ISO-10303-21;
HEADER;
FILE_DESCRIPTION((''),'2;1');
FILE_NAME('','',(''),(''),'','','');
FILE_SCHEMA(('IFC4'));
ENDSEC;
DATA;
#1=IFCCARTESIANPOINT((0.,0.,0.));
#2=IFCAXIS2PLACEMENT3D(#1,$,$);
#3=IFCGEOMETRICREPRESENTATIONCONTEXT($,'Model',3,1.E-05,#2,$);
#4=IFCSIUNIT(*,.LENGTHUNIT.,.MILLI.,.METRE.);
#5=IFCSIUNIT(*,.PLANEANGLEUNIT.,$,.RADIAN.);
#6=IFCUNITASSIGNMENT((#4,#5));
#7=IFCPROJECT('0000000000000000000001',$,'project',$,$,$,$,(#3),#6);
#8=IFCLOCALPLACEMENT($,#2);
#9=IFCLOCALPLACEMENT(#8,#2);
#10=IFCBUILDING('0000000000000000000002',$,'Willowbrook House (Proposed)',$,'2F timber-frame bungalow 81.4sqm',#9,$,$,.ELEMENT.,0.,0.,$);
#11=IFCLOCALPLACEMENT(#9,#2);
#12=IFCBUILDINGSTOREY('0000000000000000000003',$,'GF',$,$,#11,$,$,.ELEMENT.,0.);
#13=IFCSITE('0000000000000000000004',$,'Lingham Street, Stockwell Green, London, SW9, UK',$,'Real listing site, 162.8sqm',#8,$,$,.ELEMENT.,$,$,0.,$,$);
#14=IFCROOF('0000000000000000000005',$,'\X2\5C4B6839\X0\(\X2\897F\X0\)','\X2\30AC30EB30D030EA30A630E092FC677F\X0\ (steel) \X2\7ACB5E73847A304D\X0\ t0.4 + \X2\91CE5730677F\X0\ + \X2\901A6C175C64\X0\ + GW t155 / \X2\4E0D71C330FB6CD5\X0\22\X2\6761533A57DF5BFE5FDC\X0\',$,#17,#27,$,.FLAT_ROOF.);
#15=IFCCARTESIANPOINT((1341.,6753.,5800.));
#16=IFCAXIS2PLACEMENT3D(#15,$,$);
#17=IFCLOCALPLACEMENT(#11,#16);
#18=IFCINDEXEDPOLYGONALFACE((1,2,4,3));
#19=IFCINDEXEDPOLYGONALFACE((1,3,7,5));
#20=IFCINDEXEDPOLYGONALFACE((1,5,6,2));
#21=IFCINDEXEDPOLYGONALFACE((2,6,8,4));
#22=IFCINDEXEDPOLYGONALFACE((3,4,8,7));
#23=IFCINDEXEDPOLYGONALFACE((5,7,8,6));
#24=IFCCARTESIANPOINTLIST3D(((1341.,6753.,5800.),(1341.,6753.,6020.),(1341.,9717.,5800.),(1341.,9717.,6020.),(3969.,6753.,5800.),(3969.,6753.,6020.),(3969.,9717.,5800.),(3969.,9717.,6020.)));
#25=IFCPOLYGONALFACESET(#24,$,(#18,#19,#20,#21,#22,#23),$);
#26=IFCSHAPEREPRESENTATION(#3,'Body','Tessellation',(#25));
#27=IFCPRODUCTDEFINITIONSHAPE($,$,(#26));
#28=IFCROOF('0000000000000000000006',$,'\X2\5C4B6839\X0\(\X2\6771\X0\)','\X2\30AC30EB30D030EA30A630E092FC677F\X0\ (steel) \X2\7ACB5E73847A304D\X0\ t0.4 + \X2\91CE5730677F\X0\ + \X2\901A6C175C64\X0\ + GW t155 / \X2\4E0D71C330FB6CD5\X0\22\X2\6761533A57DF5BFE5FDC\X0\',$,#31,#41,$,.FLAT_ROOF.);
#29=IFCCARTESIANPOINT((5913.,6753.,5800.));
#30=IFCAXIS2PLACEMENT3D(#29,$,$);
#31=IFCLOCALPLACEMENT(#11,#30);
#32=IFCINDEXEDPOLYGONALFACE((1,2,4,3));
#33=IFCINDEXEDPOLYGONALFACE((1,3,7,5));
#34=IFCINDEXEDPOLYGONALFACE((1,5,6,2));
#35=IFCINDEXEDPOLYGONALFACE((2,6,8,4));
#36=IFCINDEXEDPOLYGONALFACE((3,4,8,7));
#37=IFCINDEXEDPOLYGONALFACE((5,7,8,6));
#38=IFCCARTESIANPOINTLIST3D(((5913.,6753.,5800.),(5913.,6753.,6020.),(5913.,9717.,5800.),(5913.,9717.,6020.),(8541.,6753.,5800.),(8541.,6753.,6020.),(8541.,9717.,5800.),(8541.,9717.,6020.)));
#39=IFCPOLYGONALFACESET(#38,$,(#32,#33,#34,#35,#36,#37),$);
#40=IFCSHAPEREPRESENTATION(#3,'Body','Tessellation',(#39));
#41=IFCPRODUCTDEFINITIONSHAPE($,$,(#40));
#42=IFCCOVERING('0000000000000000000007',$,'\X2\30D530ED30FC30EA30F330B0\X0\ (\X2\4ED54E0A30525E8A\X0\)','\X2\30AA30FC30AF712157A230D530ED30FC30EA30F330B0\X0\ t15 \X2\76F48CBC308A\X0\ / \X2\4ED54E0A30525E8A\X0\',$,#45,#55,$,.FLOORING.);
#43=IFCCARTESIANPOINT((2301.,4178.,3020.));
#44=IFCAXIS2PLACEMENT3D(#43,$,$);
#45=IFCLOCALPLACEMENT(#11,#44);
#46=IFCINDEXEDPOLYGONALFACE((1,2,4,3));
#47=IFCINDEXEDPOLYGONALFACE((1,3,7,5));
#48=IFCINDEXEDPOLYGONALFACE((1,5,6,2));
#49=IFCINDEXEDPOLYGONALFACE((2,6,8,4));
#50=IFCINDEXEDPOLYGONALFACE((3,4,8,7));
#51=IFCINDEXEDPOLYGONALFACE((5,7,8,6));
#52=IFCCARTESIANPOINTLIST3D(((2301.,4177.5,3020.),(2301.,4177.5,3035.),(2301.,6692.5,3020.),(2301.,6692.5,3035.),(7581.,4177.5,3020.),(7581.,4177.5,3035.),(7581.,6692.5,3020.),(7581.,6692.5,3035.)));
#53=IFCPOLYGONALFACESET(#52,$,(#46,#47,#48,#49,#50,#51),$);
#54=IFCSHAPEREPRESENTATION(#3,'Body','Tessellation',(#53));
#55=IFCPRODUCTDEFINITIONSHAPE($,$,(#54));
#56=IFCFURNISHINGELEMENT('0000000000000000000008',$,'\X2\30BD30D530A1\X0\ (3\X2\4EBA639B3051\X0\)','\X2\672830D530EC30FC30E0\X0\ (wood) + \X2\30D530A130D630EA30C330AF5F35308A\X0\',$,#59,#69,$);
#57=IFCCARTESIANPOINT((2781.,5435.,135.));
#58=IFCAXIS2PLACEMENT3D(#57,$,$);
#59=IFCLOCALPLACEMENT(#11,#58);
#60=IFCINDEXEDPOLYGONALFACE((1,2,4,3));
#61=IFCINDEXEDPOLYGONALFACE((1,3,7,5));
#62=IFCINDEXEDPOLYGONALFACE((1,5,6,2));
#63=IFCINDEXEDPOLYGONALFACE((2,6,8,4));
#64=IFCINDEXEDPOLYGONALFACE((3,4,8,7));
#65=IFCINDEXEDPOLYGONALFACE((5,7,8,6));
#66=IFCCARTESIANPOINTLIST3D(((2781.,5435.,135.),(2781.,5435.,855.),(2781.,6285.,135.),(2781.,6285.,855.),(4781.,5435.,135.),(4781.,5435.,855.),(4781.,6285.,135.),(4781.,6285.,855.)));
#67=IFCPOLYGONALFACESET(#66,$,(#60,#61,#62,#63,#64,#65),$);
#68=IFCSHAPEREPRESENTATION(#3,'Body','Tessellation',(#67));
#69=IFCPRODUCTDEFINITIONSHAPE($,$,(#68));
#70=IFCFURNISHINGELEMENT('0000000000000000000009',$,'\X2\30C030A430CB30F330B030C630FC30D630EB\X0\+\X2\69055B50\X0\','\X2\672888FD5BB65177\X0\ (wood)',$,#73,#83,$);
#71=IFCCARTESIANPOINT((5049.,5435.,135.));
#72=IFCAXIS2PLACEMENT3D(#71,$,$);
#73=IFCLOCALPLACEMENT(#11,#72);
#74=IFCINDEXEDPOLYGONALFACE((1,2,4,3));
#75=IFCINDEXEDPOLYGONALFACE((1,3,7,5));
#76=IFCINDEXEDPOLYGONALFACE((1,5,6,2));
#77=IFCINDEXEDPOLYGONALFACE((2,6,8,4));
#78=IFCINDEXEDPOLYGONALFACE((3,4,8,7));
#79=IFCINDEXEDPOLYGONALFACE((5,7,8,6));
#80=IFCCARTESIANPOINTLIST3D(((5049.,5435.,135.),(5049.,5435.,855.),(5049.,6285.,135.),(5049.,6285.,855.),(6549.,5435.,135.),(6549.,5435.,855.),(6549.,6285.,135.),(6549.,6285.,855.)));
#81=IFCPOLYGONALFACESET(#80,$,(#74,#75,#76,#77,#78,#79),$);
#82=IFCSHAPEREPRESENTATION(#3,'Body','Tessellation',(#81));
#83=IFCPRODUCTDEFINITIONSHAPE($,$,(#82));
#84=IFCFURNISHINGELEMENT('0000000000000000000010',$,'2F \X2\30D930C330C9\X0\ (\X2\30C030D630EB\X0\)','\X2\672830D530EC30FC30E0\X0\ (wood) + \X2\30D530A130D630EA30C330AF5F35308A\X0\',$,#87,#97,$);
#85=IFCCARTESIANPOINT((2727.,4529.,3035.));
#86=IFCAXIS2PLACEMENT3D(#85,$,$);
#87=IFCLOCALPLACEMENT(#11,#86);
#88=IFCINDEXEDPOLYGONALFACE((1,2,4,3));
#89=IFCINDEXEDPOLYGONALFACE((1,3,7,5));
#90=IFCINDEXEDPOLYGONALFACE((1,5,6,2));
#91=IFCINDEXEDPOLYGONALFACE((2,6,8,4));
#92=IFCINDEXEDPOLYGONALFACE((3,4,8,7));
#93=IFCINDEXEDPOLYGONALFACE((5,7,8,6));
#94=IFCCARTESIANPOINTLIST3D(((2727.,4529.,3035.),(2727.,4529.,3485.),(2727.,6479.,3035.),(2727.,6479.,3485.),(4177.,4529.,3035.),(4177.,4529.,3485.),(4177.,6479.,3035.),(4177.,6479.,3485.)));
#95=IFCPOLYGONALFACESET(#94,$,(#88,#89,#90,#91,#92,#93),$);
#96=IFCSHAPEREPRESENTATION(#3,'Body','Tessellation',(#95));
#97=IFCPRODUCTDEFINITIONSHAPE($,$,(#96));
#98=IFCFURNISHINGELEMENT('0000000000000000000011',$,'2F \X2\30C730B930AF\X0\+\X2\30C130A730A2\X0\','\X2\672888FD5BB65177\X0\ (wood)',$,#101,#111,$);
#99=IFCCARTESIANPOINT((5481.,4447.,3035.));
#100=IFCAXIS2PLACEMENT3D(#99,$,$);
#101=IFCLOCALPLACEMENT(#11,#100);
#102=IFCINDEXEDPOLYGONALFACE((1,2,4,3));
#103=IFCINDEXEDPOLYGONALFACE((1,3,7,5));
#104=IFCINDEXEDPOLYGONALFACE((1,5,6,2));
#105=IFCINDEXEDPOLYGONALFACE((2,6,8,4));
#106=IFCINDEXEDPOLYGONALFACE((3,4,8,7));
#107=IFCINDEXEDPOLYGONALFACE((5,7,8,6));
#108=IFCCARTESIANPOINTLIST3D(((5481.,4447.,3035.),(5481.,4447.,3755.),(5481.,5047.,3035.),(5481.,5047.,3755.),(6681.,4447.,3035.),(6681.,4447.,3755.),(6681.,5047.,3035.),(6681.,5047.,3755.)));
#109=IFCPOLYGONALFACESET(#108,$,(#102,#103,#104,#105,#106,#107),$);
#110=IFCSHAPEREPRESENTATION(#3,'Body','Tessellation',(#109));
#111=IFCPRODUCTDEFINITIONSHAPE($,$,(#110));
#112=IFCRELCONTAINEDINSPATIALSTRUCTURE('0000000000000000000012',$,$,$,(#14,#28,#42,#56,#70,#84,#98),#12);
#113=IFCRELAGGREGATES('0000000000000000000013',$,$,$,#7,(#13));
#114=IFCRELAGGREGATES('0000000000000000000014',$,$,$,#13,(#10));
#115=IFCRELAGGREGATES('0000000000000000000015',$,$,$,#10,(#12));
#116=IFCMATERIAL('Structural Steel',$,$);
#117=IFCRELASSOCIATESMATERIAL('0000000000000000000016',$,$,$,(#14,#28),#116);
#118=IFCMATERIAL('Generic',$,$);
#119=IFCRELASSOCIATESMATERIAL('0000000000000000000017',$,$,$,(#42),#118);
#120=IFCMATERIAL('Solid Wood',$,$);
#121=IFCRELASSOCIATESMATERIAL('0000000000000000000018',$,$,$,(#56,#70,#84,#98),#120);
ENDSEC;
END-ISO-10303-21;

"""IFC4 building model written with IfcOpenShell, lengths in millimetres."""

from ifc_helpers import new_model, si_unit, frame, frame_2d, origin, place, context, project, spatial, rectangle, extrude, material, element, save


model = new_model("IFC4")

# Units and contexts
model_context = context("Model", 3, precision=1e-05, world=origin())
ifc_project = project(units=[si_unit("LENGTHUNIT", "METRE", prefix="MILLI"), si_unit("PLANEANGLEUNIT", "RADIAN")], contexts=[model_context])

# Site, building, storey
site_placement = place(None, origin())
site = spatial("IfcSite", under=ifc_project, at=site_placement, Name="Lingham Street, Stockwell Green, London, SW9, UK", ObjectType="Real listing site, 162.8sqm", CompositionType="ELEMENT", RefElevation=0.0)
building_placement = place(site_placement, origin())
building = spatial("IfcBuilding", under=site, at=building_placement, Name="Willowbrook House (Proposed)", ObjectType="2F timber-frame bungalow 81.4sqm", CompositionType="ELEMENT", ElevationOfRefHeight=0.0, ElevationOfTerrain=0.0)
storey_placement = place(building_placement, origin())
storey = spatial("IfcBuildingStorey", under=building, at=storey_placement, Name="GF", CompositionType="ELEMENT", Elevation=0.0)

# Shared definitions
ifc_material_1 = material(Name="Solid Wood")

# Roofs
ifc_material_2 = material(Name="Structural Steel")
roof_1_placement = place(storey_placement, frame((1341.0, 6753.0, 5800.0)))
element("IfcRoof", 1, at=roof_1_placement, inside=storey, material=ifc_material_2, Name="屋根(西)", Description="ガルバリウム鋼板 (steel) 立平葺き t0.4 + 野地板 + 通気層 + GW t155 / 不燃・法22条区域対応", PredefinedType="FLAT_ROOF", context=model_context, shape_type="SweptSolid", body=[
    extrude(rectangle(XDim=2628.0, YDim=2964.0, at=frame_2d((1314.0, 1482.0))), frame((1341.0, 6753.0, 5800.0)), (0.0, 0.0, 1.0), 220.0),
])
roof_2_placement = place(storey_placement, frame((5913.0, 6753.0, 5800.0)))
element("IfcRoof", 2, at=roof_2_placement, inside=storey, material=ifc_material_2, Name="屋根(東)", Description="ガルバリウム鋼板 (steel) 立平葺き t0.4 + 野地板 + 通気層 + GW t155 / 不燃・法22条区域対応", PredefinedType="FLAT_ROOF", context=model_context, shape_type="SweptSolid", body=[
    extrude(rectangle(XDim=2628.0, YDim=2964.0, at=frame_2d((1314.0, 1482.0))), frame((5913.0, 6753.0, 5800.0)), (0.0, 0.0, 1.0), 220.0),
])

# Covering
ifc_material_3 = material(Name="Generic")
covering_placement = place(storey_placement, frame((2301.0, 4178.0, 3020.0)))
element("IfcCovering", 3, at=covering_placement, inside=storey, material=ifc_material_3, Name="フローリング (仕上げ床)", Description="オーク無垢フローリング t15 直貼り / 仕上げ床", PredefinedType="FLOORING", context=model_context, shape_type="SweptSolid", body=[
    extrude(rectangle(XDim=5280.0, YDim=2515.0, at=frame_2d((2640.0, 1257.0))), frame((2301.0, 4178.0, 3020.0)), (0.0, 0.0, 1.0), 15.0),
])

# Furnishing elements
furnishing_1_placement = place(storey_placement, frame((2781.0, 5435.0, 135.0)))
element("IfcFurnishingElement", 4, at=furnishing_1_placement, inside=storey, material=ifc_material_1, Name="ソファ (3人掛け)", Description="木フレーム (wood) + ファブリック張り", context=model_context, shape_type="SweptSolid", body=[
    extrude(rectangle(XDim=2000.0, YDim=850.0, at=frame_2d((1000.0, 425.0))), frame((2781.0, 5435.0, 135.0)), (0.0, 0.0, 1.0), 720.0),
])
furnishing_2_placement = place(storey_placement, frame((5049.0, 5435.0, 135.0)))
element("IfcFurnishingElement", 5, at=furnishing_2_placement, inside=storey, material=ifc_material_1, Name="ダイニングテーブル+椅子", Description="木製家具 (wood)", context=model_context, shape_type="SweptSolid", body=[
    extrude(rectangle(XDim=1500.0, YDim=850.0, at=frame_2d((750.0, 425.0))), frame((5049.0, 5435.0, 135.0)), (0.0, 0.0, 1.0), 720.0),
])
furnishing_3_placement = place(storey_placement, frame((2727.0, 4529.0, 3035.0)))
element("IfcFurnishingElement", 6, at=furnishing_3_placement, inside=storey, material=ifc_material_1, Name="2F ベッド (ダブル)", Description="木フレーム (wood) + ファブリック張り", context=model_context, shape_type="SweptSolid", body=[
    extrude(rectangle(XDim=1450.0, YDim=1950.0, at=frame_2d((725.0, 975.0))), frame((2727.0, 4529.0, 3035.0)), (0.0, 0.0, 1.0), 450.0),
])
furnishing_4_placement = place(storey_placement, frame((5481.0, 4447.0, 3035.0)))
element("IfcFurnishingElement", 7, at=furnishing_4_placement, inside=storey, material=ifc_material_1, Name="2F デスク+チェア", Description="木製家具 (wood)", context=model_context, shape_type="SweptSolid", body=[
    extrude(rectangle(XDim=1200.0, YDim=600.0, at=frame_2d((600.0, 300.0))), frame((5481.0, 4447.0, 3035.0)), (0.0, 0.0, 1.0), 720.0),
])

save(model, "model.ifc")
